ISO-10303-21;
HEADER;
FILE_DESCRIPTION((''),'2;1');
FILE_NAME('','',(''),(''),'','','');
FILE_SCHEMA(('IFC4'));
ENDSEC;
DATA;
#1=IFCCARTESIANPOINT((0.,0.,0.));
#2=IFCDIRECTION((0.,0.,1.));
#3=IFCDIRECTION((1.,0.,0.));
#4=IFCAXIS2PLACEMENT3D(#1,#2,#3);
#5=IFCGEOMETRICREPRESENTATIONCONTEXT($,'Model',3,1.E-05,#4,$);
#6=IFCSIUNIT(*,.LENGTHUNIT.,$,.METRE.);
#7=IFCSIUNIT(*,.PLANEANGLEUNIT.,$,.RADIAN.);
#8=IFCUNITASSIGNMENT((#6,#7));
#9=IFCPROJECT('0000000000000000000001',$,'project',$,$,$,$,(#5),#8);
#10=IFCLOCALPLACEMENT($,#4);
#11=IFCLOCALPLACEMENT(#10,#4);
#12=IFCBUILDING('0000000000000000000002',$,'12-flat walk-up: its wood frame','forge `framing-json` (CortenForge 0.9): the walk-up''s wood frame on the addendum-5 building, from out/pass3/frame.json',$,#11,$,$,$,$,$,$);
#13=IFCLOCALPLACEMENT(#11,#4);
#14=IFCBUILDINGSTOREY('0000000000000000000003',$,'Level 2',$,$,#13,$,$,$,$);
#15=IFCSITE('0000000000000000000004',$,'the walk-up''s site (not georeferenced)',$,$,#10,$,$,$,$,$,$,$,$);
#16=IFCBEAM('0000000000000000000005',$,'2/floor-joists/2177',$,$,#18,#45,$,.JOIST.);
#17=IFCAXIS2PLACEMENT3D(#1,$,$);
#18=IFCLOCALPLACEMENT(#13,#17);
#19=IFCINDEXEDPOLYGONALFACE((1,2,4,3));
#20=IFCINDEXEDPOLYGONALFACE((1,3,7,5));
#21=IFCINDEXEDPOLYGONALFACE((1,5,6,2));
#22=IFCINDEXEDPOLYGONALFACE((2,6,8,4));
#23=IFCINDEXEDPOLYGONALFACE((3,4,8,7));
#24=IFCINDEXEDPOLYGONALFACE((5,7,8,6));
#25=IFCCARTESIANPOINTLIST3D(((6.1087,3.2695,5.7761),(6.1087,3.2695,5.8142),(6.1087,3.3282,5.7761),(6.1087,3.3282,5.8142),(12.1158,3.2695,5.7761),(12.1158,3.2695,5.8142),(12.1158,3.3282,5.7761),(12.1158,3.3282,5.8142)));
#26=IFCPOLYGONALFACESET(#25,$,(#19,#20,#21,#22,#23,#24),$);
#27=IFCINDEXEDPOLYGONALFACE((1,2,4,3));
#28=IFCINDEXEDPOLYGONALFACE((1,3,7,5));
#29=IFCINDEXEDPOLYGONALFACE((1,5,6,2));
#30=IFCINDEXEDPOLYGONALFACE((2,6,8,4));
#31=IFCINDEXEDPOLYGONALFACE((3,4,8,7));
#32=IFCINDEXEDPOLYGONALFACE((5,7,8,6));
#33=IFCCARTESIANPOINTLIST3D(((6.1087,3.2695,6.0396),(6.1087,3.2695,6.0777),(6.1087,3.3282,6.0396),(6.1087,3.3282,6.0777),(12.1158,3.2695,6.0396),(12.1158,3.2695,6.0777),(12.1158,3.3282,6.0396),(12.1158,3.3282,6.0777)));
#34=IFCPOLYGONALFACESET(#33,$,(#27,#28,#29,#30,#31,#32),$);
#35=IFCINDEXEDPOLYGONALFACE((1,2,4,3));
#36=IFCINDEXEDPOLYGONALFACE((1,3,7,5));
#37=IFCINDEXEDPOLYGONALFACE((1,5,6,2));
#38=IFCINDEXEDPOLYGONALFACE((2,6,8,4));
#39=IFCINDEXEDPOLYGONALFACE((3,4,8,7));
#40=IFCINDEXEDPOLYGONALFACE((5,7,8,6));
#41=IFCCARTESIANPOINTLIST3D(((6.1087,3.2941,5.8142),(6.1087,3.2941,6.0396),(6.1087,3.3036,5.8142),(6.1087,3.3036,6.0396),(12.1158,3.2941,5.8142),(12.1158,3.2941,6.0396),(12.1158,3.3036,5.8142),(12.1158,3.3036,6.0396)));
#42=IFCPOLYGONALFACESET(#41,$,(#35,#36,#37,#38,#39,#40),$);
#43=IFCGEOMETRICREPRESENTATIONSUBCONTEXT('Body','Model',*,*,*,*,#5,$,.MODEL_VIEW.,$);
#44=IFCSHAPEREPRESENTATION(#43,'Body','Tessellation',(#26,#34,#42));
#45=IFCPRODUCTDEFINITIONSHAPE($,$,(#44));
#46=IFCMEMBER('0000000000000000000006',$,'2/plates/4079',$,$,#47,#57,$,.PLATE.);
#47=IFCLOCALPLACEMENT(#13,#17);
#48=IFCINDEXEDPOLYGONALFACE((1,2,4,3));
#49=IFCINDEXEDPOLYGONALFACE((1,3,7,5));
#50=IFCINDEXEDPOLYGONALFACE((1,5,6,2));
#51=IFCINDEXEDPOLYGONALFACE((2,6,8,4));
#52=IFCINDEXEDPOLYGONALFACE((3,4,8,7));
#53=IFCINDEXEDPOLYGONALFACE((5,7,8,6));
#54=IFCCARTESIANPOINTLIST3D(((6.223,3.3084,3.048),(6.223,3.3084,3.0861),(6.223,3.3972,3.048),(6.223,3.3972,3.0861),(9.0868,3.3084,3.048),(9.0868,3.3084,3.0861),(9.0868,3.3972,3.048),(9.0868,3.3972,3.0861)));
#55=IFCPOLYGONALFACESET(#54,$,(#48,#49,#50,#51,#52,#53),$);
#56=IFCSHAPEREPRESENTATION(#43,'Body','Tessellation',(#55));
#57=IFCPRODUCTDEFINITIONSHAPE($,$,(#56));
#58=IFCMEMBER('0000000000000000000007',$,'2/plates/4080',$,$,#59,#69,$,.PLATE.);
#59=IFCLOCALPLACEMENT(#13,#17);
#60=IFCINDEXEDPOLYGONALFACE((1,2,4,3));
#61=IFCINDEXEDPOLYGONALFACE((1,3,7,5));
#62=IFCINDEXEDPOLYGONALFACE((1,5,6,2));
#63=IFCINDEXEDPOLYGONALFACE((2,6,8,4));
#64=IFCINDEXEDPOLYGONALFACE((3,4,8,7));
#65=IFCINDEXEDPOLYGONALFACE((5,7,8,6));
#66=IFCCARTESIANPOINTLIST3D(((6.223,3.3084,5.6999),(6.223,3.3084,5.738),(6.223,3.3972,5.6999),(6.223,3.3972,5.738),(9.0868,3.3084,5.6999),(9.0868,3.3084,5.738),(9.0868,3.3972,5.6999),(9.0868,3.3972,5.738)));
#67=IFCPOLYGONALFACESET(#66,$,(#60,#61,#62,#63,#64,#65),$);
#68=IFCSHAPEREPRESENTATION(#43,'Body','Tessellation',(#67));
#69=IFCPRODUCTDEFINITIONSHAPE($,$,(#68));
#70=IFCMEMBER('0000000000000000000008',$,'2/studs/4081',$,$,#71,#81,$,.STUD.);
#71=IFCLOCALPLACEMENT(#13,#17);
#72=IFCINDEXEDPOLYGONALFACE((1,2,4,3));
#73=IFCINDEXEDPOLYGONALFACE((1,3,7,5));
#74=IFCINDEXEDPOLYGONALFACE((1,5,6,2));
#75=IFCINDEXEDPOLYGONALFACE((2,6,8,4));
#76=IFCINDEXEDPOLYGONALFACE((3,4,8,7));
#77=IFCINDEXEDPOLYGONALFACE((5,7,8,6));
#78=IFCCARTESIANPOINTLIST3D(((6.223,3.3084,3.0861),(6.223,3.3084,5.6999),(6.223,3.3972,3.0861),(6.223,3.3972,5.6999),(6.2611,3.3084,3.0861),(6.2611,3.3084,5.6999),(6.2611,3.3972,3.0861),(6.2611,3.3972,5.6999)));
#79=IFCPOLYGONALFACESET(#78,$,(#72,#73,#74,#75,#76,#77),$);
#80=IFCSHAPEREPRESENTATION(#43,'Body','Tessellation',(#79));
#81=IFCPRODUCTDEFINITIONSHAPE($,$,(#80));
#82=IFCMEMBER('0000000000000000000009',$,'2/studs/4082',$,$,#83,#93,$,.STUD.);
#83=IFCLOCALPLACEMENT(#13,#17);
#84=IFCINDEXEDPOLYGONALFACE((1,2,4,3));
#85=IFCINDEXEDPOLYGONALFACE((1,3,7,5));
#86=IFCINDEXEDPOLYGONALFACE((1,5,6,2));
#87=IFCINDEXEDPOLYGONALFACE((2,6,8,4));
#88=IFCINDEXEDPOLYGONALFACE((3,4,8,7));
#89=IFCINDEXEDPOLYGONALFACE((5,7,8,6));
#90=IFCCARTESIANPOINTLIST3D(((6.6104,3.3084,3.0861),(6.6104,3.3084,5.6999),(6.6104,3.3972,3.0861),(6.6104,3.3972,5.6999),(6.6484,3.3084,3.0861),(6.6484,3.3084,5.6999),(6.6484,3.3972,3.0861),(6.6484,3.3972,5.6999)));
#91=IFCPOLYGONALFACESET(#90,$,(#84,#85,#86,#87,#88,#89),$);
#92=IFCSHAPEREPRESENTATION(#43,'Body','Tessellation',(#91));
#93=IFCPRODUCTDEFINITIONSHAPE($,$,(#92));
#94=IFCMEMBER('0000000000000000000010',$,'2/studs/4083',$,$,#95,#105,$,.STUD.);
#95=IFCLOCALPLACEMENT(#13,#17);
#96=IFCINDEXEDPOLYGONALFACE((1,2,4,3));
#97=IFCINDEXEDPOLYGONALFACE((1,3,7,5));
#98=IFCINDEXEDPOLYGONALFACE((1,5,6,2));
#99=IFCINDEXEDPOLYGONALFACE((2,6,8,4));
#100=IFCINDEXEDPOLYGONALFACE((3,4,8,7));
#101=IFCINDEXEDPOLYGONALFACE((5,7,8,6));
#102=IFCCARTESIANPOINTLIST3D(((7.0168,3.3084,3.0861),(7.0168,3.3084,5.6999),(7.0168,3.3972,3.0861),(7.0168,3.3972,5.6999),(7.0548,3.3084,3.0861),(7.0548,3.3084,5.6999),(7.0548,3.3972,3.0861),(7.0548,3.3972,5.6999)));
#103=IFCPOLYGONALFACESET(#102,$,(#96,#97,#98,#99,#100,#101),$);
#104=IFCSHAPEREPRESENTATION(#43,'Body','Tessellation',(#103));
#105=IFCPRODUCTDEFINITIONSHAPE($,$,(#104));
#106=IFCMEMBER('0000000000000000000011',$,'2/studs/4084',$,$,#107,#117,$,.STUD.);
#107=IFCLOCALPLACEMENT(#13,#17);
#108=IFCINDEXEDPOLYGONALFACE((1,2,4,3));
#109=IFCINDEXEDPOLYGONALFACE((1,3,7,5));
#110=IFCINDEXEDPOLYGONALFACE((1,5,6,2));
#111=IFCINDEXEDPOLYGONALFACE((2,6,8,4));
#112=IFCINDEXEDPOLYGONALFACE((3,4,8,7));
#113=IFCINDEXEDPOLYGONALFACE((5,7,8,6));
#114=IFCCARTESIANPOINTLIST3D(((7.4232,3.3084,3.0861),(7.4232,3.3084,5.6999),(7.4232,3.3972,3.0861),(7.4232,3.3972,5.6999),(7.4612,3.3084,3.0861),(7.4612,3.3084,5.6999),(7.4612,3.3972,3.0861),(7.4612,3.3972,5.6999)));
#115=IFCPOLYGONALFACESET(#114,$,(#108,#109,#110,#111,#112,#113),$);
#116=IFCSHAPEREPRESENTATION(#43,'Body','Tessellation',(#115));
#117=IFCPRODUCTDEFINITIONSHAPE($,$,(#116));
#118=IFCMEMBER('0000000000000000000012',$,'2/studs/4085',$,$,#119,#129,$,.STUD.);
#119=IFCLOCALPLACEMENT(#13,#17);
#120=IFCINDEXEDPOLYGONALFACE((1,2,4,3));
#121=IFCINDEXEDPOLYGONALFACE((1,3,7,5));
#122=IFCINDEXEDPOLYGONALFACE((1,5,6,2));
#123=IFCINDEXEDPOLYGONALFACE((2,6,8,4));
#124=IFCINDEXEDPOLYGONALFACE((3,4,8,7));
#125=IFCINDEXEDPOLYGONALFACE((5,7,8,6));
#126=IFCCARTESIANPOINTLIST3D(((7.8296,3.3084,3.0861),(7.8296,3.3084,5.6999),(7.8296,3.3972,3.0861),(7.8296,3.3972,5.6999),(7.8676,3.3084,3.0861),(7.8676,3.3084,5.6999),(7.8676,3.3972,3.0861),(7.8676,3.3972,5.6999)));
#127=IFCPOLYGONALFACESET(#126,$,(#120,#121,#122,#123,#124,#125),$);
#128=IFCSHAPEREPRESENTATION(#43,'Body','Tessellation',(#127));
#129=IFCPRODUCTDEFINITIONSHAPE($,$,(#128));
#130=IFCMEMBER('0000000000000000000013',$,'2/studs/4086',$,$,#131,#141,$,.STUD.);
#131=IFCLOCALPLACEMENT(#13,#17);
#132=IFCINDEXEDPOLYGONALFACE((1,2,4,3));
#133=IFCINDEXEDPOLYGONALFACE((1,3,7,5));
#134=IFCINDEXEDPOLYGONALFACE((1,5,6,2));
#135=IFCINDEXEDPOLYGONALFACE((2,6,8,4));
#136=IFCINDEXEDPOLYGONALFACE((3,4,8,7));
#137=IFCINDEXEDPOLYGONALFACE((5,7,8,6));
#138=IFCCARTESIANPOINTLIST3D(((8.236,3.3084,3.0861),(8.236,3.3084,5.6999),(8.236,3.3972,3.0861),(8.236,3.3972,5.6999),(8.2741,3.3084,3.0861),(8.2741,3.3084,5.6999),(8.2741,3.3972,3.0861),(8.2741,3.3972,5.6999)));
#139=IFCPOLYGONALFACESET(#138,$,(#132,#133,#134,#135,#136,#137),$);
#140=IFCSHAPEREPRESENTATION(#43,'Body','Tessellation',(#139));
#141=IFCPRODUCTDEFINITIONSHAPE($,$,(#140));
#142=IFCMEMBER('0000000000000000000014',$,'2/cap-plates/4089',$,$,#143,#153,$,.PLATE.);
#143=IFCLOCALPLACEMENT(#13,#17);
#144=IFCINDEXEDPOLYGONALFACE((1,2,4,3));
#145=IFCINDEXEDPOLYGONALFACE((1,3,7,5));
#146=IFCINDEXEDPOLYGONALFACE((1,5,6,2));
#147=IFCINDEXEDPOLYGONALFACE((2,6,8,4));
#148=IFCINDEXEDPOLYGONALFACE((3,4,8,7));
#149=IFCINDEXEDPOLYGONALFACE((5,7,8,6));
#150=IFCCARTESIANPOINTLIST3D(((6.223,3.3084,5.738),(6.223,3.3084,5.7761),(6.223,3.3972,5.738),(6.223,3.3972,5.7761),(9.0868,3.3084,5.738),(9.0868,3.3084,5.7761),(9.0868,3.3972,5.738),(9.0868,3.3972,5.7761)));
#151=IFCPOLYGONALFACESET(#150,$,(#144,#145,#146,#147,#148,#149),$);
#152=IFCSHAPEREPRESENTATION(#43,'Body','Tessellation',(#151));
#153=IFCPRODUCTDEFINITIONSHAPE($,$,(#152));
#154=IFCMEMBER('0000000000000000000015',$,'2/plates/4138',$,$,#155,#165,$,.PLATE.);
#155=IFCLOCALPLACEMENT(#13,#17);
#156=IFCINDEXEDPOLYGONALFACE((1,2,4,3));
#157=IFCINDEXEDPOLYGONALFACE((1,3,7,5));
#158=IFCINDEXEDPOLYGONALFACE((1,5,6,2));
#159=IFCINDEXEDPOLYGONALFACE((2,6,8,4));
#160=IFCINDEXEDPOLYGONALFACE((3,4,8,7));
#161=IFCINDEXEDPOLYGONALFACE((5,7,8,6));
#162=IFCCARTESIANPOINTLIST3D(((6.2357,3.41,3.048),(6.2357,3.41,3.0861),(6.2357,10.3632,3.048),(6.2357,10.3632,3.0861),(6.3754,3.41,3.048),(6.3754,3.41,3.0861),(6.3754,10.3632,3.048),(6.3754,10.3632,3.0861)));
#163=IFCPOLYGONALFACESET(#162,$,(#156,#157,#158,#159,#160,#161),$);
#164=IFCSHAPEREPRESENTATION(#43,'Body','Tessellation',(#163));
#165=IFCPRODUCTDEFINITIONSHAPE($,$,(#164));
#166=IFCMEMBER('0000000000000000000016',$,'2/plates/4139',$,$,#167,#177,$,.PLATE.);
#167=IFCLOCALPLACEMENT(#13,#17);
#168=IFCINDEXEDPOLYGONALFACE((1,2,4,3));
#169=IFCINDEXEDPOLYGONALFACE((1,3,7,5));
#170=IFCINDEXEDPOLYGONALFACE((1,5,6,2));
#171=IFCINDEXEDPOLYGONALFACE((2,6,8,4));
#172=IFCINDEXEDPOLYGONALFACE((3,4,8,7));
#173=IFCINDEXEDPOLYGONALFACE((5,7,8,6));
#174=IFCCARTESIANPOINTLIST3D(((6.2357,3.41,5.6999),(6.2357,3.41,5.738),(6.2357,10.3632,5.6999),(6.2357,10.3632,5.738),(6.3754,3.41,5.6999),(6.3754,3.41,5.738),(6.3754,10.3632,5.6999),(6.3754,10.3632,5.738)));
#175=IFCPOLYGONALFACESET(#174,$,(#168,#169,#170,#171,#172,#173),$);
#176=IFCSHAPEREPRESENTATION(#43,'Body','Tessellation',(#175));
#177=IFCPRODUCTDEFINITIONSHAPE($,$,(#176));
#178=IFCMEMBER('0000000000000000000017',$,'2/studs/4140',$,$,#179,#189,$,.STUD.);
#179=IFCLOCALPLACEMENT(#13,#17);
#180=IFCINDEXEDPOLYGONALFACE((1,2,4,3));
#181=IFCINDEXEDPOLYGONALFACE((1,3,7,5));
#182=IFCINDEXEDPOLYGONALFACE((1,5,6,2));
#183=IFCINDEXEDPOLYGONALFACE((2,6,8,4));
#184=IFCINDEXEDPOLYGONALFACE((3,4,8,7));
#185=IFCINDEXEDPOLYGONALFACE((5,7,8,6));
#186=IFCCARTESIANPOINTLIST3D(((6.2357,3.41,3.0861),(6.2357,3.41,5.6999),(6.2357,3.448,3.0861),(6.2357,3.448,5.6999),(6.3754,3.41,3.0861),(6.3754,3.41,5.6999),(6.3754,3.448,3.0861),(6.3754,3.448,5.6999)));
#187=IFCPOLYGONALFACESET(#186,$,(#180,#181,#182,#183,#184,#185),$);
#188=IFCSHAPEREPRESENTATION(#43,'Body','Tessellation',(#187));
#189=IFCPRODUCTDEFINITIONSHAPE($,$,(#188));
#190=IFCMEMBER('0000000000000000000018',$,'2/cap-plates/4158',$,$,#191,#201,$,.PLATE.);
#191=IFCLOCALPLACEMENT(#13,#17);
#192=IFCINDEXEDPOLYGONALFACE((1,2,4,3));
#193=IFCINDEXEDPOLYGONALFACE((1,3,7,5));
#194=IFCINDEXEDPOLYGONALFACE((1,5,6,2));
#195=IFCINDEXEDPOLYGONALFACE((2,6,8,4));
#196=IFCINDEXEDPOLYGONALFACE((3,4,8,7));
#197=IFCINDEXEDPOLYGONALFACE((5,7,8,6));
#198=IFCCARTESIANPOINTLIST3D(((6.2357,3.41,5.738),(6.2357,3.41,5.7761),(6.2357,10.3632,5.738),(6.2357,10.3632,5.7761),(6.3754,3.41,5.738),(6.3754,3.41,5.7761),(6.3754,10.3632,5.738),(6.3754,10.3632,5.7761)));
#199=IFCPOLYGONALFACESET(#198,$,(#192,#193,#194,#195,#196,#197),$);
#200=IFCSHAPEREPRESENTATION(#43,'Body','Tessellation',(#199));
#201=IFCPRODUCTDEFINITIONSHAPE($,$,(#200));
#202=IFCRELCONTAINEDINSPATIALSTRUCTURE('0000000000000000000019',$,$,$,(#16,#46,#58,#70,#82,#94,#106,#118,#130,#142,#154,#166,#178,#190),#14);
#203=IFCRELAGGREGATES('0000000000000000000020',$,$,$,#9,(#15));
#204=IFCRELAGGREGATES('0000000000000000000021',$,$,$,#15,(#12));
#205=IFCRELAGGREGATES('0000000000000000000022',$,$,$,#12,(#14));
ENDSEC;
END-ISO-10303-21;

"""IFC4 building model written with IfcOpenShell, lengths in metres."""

from ifc_helpers import new_model, si_unit, frame, frame_2d, origin, origin_with_axes, place, context, subcontext, project, spatial, rectangle, extrude, element, save


model = new_model("IFC4")

# Units and contexts
model_context = context("Model", 3, precision=1e-05, world=origin_with_axes())
body_context = subcontext(model_context, "Body", "Model", "MODEL_VIEW")
ifc_project = project(units=[si_unit("LENGTHUNIT", "METRE"), si_unit("PLANEANGLEUNIT", "RADIAN")], contexts=[model_context])

# Site, building, storey
site_placement = place(None, origin_with_axes())
site = spatial("IfcSite", under=ifc_project, at=site_placement, Name="the walk-up's site (not georeferenced)")
building_placement = place(site_placement, origin_with_axes())
building = spatial("IfcBuilding", under=site, at=building_placement, Name="12-flat walk-up: its wood frame", Description="forge `framing-json` (CortenForge 0.9): the walk-up's wood frame on the addendum-5 building, from out/pass3/frame.json")
storey_placement = place(building_placement, origin_with_axes())
storey = spatial("IfcBuildingStorey", under=building, at=storey_placement, Name="Level 2")

# Beam
for number, where, z_axis, x_axis, name in (
    (1, (6.1087, 3.2695, 5.7761), (0.0, 0.0, 1.0), (1.0, 0.0, 0.0), "2/floor-joists/2177"),
):
    element("IfcBeam", number, at=place(storey_placement, frame(where, z_axis=z_axis, x_axis=x_axis)), inside=storey, Name=name, PredefinedType="JOIST", context=body_context, shape_type="SweptSolid", body=[
        extrude(rectangle(XDim=6.0071, YDim=0.0587, at=frame_2d((3.0036, 0.0294))), origin(), (0.0, 0.0, 1.0), 0.0381),
        extrude(rectangle(XDim=6.0071, YDim=0.0587, at=frame_2d((3.0036, 0.0294))), frame((0.0, 0.0, 0.2635)), (0.0, 0.0, 1.0), 0.0381),
        extrude(rectangle(XDim=6.0071, YDim=0.0095, at=frame_2d((3.0036, 0.0048))), frame((0.0, 0.0246, 0.0381)), (0.0, 0.0, 1.0), 0.2254),
    ])

# Members
for number, where, z_axis, x_axis, name in (
    (2, (6.223, 3.3083, 3.048), (0.0, 0.0, 1.0), (1.0, 0.0, 0.0), "2/plates/4079"),
    (3, (6.223, 3.3083, 5.6999), (0.0, 0.0, 1.0), (1.0, 0.0, 0.0), "2/plates/4080"),
):
    element("IfcMember", number, at=place(storey_placement, frame(where, z_axis=z_axis, x_axis=x_axis)), inside=storey, Name=name, PredefinedType="PLATE", context=body_context, shape_type="SweptSolid", body=[
        extrude(rectangle(XDim=2.8639, YDim=0.0889, at=frame_2d((1.4319, 0.0445))), origin(), (0.0, 0.0, 1.0), 0.0381),
    ])
for number, where, z_axis, x_axis, name in (
    (4, (6.223, 3.3083, 3.0861), (0.0, 0.0, 1.0), (1.0, 0.0, 0.0), "2/studs/4081"),
    (5, (6.6104, 3.3083, 3.0861), (0.0, 0.0, 1.0), (1.0, 0.0, 0.0), "2/studs/4082"),
    (6, (7.0168, 3.3083, 3.0861), (0.0, 0.0, 1.0), (1.0, 0.0, 0.0), "2/studs/4083"),
    (7, (7.4231, 3.3083, 3.0861), (0.0, 0.0, 1.0), (1.0, 0.0, 0.0), "2/studs/4084"),
    (8, (7.8296, 3.3083, 3.0861), (0.0, 0.0, 1.0), (1.0, 0.0, 0.0), "2/studs/4085"),
    (9, (8.236, 3.3083, 3.0861), (0.0, 0.0, 1.0), (1.0, 0.0, 0.0), "2/studs/4086"),
):
    element("IfcMember", number, at=place(storey_placement, frame(where, z_axis=z_axis, x_axis=x_axis)), inside=storey, Name=name, PredefinedType="STUD", context=body_context, shape_type="SweptSolid", body=[
        extrude(rectangle(XDim=0.0381, YDim=0.0889, at=frame_2d((0.0191, 0.0445))), origin(), (0.0, 0.0, 1.0), 2.6138),
    ])
member_1_placement = place(storey_placement, frame((6.223, 3.3083, 5.738), z_axis=(0.0, 0.0, 1.0), x_axis=(1.0, 0.0, 0.0)))
element("IfcMember", 10, at=member_1_placement, inside=storey, Name="2/cap-plates/4089", PredefinedType="PLATE", context=body_context, shape_type="SweptSolid", body=[
    extrude(rectangle(XDim=2.8639, YDim=0.0889, at=frame_2d((1.4319, 0.0445))), origin(), (0.0, 0.0, 1.0), 0.0381),
])
for number, where, z_axis, x_axis, name in (
    (11, (6.2357, 3.4099, 3.048), (0.0, 0.0, 1.0), (1.0, 0.0, 0.0), "2/plates/4138"),
    (12, (6.2357, 3.4099, 5.6999), (0.0, 0.0, 1.0), (1.0, 0.0, 0.0), "2/plates/4139"),
):
    element("IfcMember", number, at=place(storey_placement, frame(where, z_axis=z_axis, x_axis=x_axis)), inside=storey, Name=name, PredefinedType="PLATE", context=body_context, shape_type="SweptSolid", body=[
        extrude(rectangle(XDim=0.1397, YDim=6.9533, at=frame_2d((0.0699, 3.4766))), origin(), (0.0, 0.0, 1.0), 0.0381),
    ])
member_2_placement = place(storey_placement, frame((6.2357, 3.4099, 3.0861), z_axis=(0.0, 0.0, 1.0), x_axis=(1.0, 0.0, 0.0)))
element("IfcMember", 13, at=member_2_placement, inside=storey, Name="2/studs/4140", PredefinedType="STUD", context=body_context, shape_type="SweptSolid", body=[
    extrude(rectangle(XDim=0.1397, YDim=0.0381, at=frame_2d((0.0699, 0.0191))), origin(), (0.0, 0.0, 1.0), 2.6138),
])
member_3_placement = place(storey_placement, frame((6.2357, 3.4099, 5.738), z_axis=(0.0, 0.0, 1.0), x_axis=(1.0, 0.0, 0.0)))
element("IfcMember", 14, at=member_3_placement, inside=storey, Name="2/cap-plates/4158", PredefinedType="PLATE", context=body_context, shape_type="SweptSolid", body=[
    extrude(rectangle(XDim=0.1397, YDim=6.9533, at=frame_2d((0.0699, 3.4766))), origin(), (0.0, 0.0, 1.0), 0.0381),
])

save(model, "model.ifc")
